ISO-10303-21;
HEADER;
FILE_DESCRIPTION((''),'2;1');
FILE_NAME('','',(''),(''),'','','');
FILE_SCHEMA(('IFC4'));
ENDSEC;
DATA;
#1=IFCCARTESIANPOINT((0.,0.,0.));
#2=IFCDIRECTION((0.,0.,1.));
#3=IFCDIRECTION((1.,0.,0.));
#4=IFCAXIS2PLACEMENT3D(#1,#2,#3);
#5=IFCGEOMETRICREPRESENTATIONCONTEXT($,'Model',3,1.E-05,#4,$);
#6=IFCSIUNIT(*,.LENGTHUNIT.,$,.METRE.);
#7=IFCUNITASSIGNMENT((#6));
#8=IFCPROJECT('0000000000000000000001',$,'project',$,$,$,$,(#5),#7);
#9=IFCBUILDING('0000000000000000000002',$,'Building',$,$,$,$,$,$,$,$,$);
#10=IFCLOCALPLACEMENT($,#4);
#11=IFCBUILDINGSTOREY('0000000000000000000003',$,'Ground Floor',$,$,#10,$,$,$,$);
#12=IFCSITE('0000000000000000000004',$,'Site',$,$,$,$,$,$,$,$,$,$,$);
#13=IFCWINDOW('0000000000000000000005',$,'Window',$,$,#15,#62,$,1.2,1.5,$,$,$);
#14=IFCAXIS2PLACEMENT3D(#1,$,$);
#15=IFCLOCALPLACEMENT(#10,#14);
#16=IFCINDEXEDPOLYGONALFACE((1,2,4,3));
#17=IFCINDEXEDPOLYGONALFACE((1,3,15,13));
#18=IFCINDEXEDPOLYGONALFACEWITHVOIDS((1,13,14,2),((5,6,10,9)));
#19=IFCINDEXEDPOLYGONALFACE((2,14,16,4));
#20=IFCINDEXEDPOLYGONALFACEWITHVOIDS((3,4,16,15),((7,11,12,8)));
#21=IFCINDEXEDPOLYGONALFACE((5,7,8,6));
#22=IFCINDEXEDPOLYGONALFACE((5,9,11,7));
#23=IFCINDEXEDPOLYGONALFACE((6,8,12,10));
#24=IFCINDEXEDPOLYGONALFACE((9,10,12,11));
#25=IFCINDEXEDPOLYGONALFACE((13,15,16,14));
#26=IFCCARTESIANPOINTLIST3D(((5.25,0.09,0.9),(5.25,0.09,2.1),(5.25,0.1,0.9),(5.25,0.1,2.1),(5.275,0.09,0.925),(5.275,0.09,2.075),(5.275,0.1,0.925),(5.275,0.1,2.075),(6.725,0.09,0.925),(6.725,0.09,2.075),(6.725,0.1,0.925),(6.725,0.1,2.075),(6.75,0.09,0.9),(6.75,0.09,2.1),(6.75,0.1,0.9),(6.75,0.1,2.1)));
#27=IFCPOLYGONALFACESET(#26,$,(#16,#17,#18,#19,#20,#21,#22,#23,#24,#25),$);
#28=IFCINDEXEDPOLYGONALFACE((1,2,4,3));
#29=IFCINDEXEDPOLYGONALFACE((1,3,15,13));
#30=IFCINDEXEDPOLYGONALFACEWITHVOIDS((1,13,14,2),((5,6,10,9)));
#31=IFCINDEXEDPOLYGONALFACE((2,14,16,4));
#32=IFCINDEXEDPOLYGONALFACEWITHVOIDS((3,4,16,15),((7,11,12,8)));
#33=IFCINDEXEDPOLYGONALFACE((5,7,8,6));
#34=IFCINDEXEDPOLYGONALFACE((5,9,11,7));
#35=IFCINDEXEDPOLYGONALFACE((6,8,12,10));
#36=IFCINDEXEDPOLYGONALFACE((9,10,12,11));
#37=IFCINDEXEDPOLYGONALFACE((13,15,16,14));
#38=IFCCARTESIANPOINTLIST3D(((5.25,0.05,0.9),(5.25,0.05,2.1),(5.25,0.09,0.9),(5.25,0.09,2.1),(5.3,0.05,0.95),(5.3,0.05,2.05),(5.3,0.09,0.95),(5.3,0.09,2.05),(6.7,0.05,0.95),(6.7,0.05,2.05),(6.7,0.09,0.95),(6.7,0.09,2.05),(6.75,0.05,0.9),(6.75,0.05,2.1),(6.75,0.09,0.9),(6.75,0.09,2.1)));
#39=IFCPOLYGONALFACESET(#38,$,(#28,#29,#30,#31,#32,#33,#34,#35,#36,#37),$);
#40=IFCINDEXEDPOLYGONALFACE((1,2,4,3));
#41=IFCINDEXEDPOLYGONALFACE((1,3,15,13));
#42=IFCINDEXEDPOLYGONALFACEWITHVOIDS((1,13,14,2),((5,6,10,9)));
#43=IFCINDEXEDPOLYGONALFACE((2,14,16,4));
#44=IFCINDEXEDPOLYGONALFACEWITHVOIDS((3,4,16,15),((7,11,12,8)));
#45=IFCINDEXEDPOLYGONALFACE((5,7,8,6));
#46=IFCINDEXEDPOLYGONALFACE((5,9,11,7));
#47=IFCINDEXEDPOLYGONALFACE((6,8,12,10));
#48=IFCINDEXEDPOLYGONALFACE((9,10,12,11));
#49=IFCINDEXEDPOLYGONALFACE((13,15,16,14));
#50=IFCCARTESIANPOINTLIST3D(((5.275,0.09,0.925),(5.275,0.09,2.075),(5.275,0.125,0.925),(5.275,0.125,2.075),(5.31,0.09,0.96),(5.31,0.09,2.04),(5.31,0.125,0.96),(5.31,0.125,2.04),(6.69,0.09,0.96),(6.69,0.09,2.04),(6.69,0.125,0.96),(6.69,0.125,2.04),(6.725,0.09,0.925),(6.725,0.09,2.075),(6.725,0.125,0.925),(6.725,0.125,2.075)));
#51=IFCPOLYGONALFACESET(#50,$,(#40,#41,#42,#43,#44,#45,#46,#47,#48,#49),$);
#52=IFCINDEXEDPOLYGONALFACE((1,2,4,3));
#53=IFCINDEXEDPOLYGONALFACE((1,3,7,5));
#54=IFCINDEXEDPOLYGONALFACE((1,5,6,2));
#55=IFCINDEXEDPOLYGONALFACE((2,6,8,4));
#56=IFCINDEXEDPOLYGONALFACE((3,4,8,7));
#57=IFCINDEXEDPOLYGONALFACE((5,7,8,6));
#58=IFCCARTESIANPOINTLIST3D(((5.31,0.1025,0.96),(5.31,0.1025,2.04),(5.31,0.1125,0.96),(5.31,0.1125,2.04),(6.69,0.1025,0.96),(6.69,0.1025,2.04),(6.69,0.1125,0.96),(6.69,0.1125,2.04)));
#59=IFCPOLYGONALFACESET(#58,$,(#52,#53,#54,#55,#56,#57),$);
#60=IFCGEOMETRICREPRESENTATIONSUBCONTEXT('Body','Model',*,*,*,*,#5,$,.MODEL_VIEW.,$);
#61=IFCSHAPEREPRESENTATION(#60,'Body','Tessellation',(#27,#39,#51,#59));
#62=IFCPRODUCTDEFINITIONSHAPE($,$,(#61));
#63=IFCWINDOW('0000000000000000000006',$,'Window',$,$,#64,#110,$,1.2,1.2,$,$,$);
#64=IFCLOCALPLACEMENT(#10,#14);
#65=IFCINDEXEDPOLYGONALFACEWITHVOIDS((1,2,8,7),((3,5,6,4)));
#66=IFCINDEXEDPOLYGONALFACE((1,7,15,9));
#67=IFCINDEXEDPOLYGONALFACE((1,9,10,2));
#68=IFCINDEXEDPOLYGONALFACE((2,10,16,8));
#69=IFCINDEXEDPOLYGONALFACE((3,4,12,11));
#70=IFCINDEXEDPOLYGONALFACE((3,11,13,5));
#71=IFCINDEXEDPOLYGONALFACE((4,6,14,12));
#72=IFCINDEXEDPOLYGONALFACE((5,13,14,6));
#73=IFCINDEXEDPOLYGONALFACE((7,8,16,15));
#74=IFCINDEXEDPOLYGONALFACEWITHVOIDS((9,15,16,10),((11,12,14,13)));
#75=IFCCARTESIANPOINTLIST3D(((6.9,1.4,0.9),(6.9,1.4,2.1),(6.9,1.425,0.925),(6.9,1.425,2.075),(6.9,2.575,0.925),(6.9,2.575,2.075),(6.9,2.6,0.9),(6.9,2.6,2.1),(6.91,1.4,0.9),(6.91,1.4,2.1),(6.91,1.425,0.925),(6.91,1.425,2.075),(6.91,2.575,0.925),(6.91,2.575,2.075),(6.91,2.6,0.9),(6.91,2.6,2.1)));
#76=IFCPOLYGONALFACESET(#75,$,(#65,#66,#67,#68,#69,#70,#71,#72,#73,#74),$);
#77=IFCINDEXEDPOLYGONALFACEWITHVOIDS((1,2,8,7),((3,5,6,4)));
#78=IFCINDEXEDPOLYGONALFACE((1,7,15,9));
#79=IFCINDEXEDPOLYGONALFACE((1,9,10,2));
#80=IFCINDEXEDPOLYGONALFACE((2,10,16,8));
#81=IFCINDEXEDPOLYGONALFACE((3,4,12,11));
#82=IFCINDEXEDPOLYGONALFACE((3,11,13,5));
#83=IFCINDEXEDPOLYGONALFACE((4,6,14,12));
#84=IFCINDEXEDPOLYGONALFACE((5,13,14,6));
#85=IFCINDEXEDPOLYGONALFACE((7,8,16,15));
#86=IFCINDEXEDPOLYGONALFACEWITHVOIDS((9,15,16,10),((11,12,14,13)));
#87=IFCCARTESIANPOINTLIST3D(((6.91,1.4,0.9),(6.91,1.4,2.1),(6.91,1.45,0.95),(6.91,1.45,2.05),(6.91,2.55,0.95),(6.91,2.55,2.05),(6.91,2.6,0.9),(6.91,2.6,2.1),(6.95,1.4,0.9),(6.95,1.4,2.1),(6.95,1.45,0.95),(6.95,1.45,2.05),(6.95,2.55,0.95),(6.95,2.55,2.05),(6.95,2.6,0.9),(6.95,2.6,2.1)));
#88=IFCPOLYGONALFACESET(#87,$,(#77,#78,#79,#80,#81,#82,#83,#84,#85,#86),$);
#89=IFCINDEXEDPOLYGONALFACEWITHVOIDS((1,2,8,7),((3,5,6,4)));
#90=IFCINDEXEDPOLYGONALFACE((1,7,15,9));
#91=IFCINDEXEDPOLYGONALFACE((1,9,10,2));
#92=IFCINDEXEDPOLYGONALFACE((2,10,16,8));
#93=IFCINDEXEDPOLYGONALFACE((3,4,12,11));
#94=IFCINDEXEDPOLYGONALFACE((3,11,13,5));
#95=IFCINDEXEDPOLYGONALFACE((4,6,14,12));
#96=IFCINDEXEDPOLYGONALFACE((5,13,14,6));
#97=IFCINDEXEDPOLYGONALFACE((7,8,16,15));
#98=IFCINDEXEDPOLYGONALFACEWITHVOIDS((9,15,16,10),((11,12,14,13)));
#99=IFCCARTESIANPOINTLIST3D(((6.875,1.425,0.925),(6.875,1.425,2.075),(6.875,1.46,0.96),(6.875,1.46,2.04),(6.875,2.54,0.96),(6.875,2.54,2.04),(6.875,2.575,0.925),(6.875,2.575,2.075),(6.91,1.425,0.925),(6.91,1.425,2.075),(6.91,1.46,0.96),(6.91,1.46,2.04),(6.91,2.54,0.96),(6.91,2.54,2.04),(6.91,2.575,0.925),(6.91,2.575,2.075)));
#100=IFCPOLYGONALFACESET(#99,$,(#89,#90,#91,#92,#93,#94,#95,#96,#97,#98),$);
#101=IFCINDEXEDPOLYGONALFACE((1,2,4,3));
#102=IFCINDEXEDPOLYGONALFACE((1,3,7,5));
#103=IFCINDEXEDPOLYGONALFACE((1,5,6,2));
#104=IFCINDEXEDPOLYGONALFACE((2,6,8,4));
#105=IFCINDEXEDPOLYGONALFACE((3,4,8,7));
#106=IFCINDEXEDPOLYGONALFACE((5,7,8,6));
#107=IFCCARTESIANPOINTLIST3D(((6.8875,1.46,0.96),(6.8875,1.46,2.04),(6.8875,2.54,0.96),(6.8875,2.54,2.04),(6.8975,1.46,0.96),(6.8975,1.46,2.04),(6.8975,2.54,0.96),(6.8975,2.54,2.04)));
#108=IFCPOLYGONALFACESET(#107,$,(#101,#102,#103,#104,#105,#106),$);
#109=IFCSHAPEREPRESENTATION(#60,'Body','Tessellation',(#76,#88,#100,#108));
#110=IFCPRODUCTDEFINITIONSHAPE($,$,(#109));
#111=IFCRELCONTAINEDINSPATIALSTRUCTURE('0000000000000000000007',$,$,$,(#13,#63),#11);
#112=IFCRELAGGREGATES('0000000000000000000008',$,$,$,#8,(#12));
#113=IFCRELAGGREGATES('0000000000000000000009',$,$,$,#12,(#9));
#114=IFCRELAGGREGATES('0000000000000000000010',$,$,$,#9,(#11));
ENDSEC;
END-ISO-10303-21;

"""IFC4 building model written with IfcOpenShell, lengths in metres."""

from ifc_helpers import new_model, si_unit, frame, origin_with_axes, place, context, subcontext, project, spatial, line, indexed_curve, outline, extrude, element, save


model = new_model("IFC4")

# Units and contexts
model_context = context("Model", 3, precision=1e-05, world=origin_with_axes())
body_context = subcontext(model_context, "Body", "Model", "MODEL_VIEW")
ifc_project = project(units=[si_unit("LENGTHUNIT", "METRE")], contexts=[model_context])

# Site, building, storey
site = spatial("IfcSite", under=ifc_project, Name="Site")
building = spatial("IfcBuilding", under=site, Name="Building")
storey_placement = place(None, origin_with_axes())
storey = spatial("IfcBuildingStorey", under=building, at=storey_placement, Name="Ground Floor")

# Windows
window_1_placement = place(storey_placement, frame((5.25, 0.0, 0.9), z_axis=(0.0, 0.0, 1.0), x_axis=(1.0, 0.0, 0.0)))
element("IfcWindow", 1, at=window_1_placement, inside=storey, Name="Window", OverallHeight=1.2, OverallWidth=1.5, context=body_context, shape_type="SweptSolid", body=[
    extrude(outline(indexed_curve([(0.0, 0.0), (1.5, 0.0), (1.5, 1.2), (0.0, 1.2)], segments=[line(1, 2, 3, 4, 1)]), holes=[indexed_curve([(0.025, 0.025), (1.475, 0.025), (1.475, 1.175), (0.025, 1.175)], segments=[line(1, 2, 3, 4, 1)])]), frame((0.0, 0.09, 0.0), z_axis=(0.0, -1.0, 0.0), x_axis=(1.0, 0.0, 0.0)), (0.0, 0.0, -1.0), 0.01),
    extrude(outline(indexed_curve([(0.0, 0.0), (1.5, 0.0), (1.5, 1.2), (0.0, 1.2)], segments=[line(1, 2, 3, 4, 1)]), holes=[indexed_curve([(0.05, 0.05), (1.45, 0.05), (1.45, 1.15), (0.05, 1.15)], segments=[line(1, 2, 3, 4, 1)])]), frame((0.0, 0.05, 0.0), z_axis=(0.0, -1.0, 0.0), x_axis=(1.0, 0.0, 0.0)), (0.0, 0.0, -1.0), 0.04),
    extrude(outline(indexed_curve([(0.0, 0.0), (1.45, 0.0), (1.45, 1.15), (0.0, 1.15)], segments=[line(1, 2, 3, 4, 1)]), holes=[indexed_curve([(0.035, 0.035), (1.415, 0.035), (1.415, 1.115), (0.035, 1.115)], segments=[line(1, 2, 3, 4, 1)])]), frame((0.025, 0.09, 0.025), z_axis=(0.0, -1.0, 0.0), x_axis=(1.0, 0.0, 0.0)), (0.0, 0.0, -1.0), 0.035),
    extrude(outline(indexed_curve([(0.035, 0.035), (1.415, 0.035), (1.415, 1.115), (0.035, 1.115)], segments=[line(1, 2, 3, 4, 1)])), frame((0.025, 0.1025, 0.025), z_axis=(0.0, -1.0, 0.0), x_axis=(1.0, 0.0, 0.0)), (0.0, 0.0, -1.0), 0.01),
])
window_2_placement = place(storey_placement, frame((7.0, 1.4, 0.9), z_axis=(0.0, 0.0, 1.0), x_axis=(0.0, 1.0, 0.0)))
element("IfcWindow", 2, at=window_2_placement, inside=storey, Name="Window", OverallHeight=1.2, OverallWidth=1.2, context=body_context, shape_type="SweptSolid", body=[
    extrude(outline(indexed_curve([(0.0, 0.0), (1.2, 0.0), (1.2, 1.2), (0.0, 1.2)], segments=[line(1, 2, 3, 4, 1)]), holes=[indexed_curve([(0.025, 0.025), (1.175, 0.025), (1.175, 1.175), (0.025, 1.175)], segments=[line(1, 2, 3, 4, 1)])]), frame((0.0, 0.09, 0.0), z_axis=(0.0, -1.0, 0.0), x_axis=(1.0, 0.0, 0.0)), (0.0, 0.0, -1.0), 0.01),
    extrude(outline(indexed_curve([(0.0, 0.0), (1.2, 0.0), (1.2, 1.2), (0.0, 1.2)], segments=[line(1, 2, 3, 4, 1)]), holes=[indexed_curve([(0.05, 0.05), (1.15, 0.05), (1.15, 1.15), (0.05, 1.15)], segments=[line(1, 2, 3, 4, 1)])]), frame((0.0, 0.05, 0.0), z_axis=(0.0, -1.0, 0.0), x_axis=(1.0, 0.0, 0.0)), (0.0, 0.0, -1.0), 0.04),
    extrude(outline(indexed_curve([(0.0, 0.0), (1.15, 0.0), (1.15, 1.15), (0.0, 1.15)], segments=[line(1, 2, 3, 4, 1)]), holes=[indexed_curve([(0.035, 0.035), (1.115, 0.035), (1.115, 1.115), (0.035, 1.115)], segments=[line(1, 2, 3, 4, 1)])]), frame((0.025, 0.09, 0.025), z_axis=(0.0, -1.0, 0.0), x_axis=(1.0, 0.0, 0.0)), (0.0, 0.0, -1.0), 0.035),
    extrude(outline(indexed_curve([(0.035, 0.035), (1.115, 0.035), (1.115, 1.115), (0.035, 1.115)], segments=[line(1, 2, 3, 4, 1)])), frame((0.025, 0.1025, 0.025), z_axis=(0.0, -1.0, 0.0), x_axis=(1.0, 0.0, 0.0)), (0.0, 0.0, -1.0), 0.01),
])

save(model, "model.ifc")
